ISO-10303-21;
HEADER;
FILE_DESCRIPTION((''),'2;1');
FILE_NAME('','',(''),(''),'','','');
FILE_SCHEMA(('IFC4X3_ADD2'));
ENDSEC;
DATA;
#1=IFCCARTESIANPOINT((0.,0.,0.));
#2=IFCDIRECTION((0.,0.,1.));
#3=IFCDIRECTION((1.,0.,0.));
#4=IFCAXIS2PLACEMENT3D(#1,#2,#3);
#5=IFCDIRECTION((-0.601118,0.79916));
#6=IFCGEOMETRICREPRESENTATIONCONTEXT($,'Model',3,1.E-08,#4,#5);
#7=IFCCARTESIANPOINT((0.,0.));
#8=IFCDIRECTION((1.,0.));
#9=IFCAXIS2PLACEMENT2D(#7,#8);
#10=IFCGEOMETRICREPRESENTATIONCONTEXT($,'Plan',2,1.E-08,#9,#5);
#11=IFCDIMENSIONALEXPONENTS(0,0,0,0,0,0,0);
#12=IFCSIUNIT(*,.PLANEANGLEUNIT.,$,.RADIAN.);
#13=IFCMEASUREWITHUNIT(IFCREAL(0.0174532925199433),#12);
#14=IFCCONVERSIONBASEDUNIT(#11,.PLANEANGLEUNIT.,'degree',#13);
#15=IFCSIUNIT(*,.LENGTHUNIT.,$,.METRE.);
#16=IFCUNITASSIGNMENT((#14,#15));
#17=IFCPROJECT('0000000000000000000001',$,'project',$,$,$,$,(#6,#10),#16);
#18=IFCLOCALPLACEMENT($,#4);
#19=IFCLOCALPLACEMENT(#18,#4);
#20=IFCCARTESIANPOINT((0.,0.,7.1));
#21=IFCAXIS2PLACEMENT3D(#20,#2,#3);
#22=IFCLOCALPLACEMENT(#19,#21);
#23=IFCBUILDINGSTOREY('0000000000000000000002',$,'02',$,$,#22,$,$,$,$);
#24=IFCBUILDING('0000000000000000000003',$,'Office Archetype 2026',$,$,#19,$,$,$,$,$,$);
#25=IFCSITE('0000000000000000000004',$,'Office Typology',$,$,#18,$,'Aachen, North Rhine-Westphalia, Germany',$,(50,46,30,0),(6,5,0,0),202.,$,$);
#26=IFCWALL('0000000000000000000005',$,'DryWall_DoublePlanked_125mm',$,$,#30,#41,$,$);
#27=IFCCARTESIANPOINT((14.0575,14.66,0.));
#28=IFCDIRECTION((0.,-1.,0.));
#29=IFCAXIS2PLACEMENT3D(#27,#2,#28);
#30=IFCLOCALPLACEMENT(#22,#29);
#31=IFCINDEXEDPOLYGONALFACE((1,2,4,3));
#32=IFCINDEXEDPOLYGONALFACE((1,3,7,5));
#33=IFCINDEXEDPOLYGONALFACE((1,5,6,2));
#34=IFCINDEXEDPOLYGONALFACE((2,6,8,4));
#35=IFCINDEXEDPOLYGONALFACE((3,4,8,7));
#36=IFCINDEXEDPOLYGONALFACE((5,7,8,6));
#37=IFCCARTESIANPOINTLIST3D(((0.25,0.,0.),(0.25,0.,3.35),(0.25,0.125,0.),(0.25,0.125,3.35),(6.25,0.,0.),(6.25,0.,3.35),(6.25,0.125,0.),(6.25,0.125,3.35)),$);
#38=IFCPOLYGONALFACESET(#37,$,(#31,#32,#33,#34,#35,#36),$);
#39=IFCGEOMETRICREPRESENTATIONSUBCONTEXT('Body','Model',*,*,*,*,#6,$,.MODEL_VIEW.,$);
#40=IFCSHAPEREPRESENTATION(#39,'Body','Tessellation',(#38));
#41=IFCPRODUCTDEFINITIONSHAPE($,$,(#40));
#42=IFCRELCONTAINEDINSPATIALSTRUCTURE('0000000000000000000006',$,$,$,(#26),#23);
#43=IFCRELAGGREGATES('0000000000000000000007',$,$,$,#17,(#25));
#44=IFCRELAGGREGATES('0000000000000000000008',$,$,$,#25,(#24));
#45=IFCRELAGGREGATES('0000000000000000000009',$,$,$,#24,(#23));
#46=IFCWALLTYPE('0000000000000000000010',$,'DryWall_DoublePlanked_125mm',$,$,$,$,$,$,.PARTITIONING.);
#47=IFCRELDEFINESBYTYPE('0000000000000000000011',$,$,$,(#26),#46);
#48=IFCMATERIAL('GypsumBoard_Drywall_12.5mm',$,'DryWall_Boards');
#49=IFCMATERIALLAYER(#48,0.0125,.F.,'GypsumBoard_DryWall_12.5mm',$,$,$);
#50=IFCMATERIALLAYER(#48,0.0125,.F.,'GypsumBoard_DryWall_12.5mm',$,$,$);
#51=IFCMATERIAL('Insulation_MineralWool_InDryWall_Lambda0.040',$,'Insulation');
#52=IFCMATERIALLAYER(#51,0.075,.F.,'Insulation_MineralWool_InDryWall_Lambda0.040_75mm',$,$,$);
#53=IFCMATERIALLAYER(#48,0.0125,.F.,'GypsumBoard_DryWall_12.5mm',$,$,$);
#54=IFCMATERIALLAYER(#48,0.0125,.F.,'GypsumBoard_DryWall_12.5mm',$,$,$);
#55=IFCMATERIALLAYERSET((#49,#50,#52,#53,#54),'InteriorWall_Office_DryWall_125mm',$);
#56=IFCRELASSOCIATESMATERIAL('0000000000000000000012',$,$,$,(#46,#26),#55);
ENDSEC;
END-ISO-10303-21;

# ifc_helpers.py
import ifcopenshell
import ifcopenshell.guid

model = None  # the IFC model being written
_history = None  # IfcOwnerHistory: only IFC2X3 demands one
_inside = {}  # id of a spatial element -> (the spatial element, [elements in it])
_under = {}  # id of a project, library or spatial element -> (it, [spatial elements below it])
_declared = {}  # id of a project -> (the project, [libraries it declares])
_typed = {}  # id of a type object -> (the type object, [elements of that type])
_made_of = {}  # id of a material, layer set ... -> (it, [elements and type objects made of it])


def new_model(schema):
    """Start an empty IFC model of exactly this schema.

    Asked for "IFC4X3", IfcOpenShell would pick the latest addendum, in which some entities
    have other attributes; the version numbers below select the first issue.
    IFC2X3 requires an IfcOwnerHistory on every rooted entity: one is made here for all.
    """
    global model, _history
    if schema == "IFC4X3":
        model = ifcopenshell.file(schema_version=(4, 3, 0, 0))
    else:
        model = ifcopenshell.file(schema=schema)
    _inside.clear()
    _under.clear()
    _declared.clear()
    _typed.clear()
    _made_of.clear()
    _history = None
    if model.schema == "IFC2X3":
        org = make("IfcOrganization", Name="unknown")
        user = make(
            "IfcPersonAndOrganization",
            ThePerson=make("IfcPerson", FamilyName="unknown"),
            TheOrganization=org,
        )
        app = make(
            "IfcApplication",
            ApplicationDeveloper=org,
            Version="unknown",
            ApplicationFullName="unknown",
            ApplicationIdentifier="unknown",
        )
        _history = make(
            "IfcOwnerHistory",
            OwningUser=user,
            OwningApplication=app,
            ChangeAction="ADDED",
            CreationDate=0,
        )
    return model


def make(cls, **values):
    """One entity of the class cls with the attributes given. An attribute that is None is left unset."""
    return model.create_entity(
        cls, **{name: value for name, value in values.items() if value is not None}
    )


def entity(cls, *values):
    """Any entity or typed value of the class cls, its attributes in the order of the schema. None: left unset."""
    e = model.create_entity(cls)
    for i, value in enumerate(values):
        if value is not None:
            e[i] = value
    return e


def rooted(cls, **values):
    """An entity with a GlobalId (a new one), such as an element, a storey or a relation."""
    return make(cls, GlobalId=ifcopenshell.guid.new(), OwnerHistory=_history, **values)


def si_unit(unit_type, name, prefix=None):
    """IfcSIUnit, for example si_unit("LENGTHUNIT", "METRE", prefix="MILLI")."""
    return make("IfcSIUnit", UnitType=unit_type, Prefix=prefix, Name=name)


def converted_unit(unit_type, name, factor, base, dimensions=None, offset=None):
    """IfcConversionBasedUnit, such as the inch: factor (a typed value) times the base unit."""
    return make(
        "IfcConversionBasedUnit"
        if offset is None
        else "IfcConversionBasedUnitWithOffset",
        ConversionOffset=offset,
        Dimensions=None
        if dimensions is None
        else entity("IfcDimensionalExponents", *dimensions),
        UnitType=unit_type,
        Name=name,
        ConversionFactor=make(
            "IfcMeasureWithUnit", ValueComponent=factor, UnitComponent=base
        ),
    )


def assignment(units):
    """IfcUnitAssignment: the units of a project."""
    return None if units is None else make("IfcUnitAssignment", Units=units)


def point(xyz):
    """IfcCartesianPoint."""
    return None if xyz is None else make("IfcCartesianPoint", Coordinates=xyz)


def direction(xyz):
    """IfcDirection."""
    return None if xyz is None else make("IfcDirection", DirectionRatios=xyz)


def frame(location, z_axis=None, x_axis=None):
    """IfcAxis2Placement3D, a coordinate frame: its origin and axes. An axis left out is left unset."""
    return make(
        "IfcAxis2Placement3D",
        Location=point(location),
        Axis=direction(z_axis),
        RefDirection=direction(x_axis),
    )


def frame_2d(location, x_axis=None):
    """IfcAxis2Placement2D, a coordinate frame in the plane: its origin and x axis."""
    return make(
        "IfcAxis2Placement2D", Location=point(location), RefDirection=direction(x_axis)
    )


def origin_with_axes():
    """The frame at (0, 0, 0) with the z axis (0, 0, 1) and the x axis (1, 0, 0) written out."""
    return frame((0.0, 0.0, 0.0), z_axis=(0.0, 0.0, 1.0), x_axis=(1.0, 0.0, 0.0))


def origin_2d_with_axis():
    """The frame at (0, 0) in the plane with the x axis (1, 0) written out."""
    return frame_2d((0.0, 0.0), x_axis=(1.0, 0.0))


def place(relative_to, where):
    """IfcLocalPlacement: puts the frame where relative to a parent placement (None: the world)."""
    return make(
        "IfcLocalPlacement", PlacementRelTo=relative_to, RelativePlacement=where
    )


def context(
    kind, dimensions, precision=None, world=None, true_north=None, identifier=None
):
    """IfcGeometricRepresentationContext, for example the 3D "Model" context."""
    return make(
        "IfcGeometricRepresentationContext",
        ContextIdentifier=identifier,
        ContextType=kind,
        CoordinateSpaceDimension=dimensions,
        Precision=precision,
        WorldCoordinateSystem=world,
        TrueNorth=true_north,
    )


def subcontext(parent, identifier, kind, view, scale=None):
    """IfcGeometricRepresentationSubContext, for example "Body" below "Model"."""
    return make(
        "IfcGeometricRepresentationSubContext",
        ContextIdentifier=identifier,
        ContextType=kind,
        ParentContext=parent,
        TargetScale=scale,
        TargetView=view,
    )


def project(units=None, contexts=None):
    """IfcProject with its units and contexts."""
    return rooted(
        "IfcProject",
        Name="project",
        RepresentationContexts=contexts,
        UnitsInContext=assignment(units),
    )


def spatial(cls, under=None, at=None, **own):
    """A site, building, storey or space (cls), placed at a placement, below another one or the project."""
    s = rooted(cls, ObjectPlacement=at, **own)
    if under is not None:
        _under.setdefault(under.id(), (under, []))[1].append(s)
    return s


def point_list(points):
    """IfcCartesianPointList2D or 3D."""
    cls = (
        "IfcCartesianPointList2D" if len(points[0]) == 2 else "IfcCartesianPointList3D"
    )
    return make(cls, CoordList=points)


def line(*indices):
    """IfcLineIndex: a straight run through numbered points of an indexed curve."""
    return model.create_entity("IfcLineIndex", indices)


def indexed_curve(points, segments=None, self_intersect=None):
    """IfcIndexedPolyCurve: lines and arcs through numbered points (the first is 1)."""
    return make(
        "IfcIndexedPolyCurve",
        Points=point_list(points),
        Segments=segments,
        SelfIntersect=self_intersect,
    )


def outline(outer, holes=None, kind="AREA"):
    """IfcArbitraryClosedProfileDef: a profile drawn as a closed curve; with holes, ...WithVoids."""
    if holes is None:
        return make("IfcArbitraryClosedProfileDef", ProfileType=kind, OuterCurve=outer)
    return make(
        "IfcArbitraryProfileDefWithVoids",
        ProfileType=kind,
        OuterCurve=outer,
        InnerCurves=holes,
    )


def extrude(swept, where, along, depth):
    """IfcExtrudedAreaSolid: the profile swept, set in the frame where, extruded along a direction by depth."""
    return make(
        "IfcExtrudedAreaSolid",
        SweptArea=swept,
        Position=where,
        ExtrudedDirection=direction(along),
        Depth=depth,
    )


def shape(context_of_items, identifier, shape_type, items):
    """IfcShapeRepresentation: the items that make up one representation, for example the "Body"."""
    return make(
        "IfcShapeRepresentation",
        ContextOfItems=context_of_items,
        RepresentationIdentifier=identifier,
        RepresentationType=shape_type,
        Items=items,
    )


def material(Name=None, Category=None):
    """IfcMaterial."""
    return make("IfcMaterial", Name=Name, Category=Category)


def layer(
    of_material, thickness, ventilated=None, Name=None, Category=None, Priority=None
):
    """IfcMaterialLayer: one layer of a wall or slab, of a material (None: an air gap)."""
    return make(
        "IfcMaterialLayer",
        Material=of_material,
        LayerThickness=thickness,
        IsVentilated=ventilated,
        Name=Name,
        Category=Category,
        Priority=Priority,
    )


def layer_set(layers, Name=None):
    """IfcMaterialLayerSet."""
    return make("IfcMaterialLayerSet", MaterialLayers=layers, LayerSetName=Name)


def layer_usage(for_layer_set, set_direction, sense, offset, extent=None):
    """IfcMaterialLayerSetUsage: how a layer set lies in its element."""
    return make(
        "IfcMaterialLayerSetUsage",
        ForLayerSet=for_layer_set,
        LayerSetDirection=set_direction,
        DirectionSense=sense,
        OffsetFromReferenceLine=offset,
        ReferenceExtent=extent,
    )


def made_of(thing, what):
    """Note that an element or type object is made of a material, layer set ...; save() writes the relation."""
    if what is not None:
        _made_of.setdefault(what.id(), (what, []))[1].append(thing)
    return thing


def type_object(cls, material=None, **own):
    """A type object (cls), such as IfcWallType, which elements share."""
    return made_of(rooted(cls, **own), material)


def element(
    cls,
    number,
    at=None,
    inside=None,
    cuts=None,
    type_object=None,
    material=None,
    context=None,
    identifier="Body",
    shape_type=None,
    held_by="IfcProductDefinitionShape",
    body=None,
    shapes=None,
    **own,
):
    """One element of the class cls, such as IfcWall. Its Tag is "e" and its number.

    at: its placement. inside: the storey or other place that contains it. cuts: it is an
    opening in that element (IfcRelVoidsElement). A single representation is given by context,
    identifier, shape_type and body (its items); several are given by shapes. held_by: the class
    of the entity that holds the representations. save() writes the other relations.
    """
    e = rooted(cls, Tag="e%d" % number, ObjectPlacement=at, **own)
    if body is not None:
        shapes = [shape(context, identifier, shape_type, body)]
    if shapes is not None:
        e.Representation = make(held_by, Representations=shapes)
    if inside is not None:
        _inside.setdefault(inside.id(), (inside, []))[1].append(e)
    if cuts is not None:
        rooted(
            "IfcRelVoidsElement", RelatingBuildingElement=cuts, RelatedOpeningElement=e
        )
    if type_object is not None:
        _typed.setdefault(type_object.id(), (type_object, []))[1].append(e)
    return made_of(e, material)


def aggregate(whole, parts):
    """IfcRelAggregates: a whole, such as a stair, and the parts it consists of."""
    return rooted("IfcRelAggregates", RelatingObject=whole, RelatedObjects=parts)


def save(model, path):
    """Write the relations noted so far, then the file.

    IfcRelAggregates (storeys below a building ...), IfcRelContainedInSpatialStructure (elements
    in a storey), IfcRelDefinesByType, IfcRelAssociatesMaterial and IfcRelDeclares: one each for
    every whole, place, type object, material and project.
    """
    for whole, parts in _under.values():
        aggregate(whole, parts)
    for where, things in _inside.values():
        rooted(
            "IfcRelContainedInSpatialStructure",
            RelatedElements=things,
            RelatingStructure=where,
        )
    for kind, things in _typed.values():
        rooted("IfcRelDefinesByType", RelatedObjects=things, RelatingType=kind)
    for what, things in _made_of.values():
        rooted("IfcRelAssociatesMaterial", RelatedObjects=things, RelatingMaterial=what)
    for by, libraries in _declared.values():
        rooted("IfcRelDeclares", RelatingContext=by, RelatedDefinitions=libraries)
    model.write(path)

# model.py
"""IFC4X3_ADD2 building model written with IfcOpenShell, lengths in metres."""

from ifc_helpers import new_model, entity, si_unit, converted_unit, direction, frame, origin_with_axes, origin_2d_with_axis, place, context, subcontext, project, spatial, line, indexed_curve, outline, extrude, material, layer, layer_set, layer_usage, type_object, element, save


model = new_model("IFC4X3_ADD2")

# Units and contexts
model_context = context("Model", 3, precision=1e-08, world=origin_with_axes(), true_north=direction((-0.601118, 0.79916)))
plan_context = context("Plan", 2, precision=1e-08, world=origin_2d_with_axis(), true_north=direction((-0.601118, 0.79916)))
body_context = subcontext(model_context, "Body", "Model", "MODEL_VIEW")
ifc_project = project(units=[converted_unit("PLANEANGLEUNIT", "degree", entity("IfcReal", 0.0174532925199433), si_unit("PLANEANGLEUNIT", "RADIAN"), dimensions=[0, 0, 0, 0, 0, 0, 0]), si_unit("LENGTHUNIT", "METRE")], contexts=[model_context, plan_context])

# Site, building, storey
site_placement = place(None, origin_with_axes())
site = spatial("IfcSite", under=ifc_project, at=site_placement, Name="Office Typology", LongName="Aachen, North Rhine-Westphalia, Germany", RefLatitude=(50, 46, 30, 0), RefLongitude=(6, 5, 0, 0), RefElevation=202.0)
building_placement = place(site_placement, origin_with_axes())
building = spatial("IfcBuilding", under=site, at=building_placement, Name="Office Archetype 2026")
storey_placement = place(building_placement, frame((0.0, 0.0, 7.1), z_axis=(0.0, 0.0, 1.0), x_axis=(1.0, 0.0, 0.0)))
storey = spatial("IfcBuildingStorey", under=building, at=storey_placement, Name="02")

# Wall
ifc_material_1 = material(Name="GypsumBoard_Drywall_12.5mm", Category="DryWall_Boards")
ifc_layer_1 = layer(ifc_material_1, 0.0125, ventilated=False, Name="GypsumBoard_DryWall_12.5mm")
ifc_layer_2 = layer(ifc_material_1, 0.0125, ventilated=False, Name="GypsumBoard_DryWall_12.5mm")
ifc_material_2 = material(Name="Insulation_MineralWool_InDryWall_Lambda0.040", Category="Insulation")
ifc_layer_3 = layer(ifc_material_2, 0.075, ventilated=False, Name="Insulation_MineralWool_InDryWall_Lambda0.040_75mm")
ifc_layer_4 = layer(ifc_material_1, 0.0125, ventilated=False, Name="GypsumBoard_DryWall_12.5mm")
ifc_layer_5 = layer(ifc_material_1, 0.0125, ventilated=False, Name="GypsumBoard_DryWall_12.5mm")
ifc_layer_set_1 = layer_set([ifc_layer_1, ifc_layer_2, ifc_layer_3, ifc_layer_4, ifc_layer_5], Name="InteriorWall_Office_DryWall_125mm")
ifc_layer_usage = layer_usage(ifc_layer_set_1, "AXIS2", "POSITIVE", 0.0)
wall_type_1 = type_object("IfcWallType", Name="DryWall_DoublePlanked_125mm", PredefinedType="PARTITIONING", material=ifc_layer_set_1)
wall_1_placement = place(storey_placement, frame((14.0575, 14.66, 0.0), z_axis=(0.0, 0.0, 1.0), x_axis=(0.0, -1.0, 0.0)))
element("IfcWall", 1, at=wall_1_placement, inside=storey, type_object=wall_type_1, material=ifc_layer_usage, Name="DryWall_DoublePlanked_125mm", context=body_context, shape_type="SweptSolid", body=[
    extrude(outline(indexed_curve([(0.25, 0.0), (0.25, 0.125), (6.25, 0.125), (6.25, 0.0)], segments=[line(1, 2, 3, 4, 1)])), origin_with_axes(), (0.0, 0.0, 1.0), 3.35),
])

save(model, "model.ifc")
